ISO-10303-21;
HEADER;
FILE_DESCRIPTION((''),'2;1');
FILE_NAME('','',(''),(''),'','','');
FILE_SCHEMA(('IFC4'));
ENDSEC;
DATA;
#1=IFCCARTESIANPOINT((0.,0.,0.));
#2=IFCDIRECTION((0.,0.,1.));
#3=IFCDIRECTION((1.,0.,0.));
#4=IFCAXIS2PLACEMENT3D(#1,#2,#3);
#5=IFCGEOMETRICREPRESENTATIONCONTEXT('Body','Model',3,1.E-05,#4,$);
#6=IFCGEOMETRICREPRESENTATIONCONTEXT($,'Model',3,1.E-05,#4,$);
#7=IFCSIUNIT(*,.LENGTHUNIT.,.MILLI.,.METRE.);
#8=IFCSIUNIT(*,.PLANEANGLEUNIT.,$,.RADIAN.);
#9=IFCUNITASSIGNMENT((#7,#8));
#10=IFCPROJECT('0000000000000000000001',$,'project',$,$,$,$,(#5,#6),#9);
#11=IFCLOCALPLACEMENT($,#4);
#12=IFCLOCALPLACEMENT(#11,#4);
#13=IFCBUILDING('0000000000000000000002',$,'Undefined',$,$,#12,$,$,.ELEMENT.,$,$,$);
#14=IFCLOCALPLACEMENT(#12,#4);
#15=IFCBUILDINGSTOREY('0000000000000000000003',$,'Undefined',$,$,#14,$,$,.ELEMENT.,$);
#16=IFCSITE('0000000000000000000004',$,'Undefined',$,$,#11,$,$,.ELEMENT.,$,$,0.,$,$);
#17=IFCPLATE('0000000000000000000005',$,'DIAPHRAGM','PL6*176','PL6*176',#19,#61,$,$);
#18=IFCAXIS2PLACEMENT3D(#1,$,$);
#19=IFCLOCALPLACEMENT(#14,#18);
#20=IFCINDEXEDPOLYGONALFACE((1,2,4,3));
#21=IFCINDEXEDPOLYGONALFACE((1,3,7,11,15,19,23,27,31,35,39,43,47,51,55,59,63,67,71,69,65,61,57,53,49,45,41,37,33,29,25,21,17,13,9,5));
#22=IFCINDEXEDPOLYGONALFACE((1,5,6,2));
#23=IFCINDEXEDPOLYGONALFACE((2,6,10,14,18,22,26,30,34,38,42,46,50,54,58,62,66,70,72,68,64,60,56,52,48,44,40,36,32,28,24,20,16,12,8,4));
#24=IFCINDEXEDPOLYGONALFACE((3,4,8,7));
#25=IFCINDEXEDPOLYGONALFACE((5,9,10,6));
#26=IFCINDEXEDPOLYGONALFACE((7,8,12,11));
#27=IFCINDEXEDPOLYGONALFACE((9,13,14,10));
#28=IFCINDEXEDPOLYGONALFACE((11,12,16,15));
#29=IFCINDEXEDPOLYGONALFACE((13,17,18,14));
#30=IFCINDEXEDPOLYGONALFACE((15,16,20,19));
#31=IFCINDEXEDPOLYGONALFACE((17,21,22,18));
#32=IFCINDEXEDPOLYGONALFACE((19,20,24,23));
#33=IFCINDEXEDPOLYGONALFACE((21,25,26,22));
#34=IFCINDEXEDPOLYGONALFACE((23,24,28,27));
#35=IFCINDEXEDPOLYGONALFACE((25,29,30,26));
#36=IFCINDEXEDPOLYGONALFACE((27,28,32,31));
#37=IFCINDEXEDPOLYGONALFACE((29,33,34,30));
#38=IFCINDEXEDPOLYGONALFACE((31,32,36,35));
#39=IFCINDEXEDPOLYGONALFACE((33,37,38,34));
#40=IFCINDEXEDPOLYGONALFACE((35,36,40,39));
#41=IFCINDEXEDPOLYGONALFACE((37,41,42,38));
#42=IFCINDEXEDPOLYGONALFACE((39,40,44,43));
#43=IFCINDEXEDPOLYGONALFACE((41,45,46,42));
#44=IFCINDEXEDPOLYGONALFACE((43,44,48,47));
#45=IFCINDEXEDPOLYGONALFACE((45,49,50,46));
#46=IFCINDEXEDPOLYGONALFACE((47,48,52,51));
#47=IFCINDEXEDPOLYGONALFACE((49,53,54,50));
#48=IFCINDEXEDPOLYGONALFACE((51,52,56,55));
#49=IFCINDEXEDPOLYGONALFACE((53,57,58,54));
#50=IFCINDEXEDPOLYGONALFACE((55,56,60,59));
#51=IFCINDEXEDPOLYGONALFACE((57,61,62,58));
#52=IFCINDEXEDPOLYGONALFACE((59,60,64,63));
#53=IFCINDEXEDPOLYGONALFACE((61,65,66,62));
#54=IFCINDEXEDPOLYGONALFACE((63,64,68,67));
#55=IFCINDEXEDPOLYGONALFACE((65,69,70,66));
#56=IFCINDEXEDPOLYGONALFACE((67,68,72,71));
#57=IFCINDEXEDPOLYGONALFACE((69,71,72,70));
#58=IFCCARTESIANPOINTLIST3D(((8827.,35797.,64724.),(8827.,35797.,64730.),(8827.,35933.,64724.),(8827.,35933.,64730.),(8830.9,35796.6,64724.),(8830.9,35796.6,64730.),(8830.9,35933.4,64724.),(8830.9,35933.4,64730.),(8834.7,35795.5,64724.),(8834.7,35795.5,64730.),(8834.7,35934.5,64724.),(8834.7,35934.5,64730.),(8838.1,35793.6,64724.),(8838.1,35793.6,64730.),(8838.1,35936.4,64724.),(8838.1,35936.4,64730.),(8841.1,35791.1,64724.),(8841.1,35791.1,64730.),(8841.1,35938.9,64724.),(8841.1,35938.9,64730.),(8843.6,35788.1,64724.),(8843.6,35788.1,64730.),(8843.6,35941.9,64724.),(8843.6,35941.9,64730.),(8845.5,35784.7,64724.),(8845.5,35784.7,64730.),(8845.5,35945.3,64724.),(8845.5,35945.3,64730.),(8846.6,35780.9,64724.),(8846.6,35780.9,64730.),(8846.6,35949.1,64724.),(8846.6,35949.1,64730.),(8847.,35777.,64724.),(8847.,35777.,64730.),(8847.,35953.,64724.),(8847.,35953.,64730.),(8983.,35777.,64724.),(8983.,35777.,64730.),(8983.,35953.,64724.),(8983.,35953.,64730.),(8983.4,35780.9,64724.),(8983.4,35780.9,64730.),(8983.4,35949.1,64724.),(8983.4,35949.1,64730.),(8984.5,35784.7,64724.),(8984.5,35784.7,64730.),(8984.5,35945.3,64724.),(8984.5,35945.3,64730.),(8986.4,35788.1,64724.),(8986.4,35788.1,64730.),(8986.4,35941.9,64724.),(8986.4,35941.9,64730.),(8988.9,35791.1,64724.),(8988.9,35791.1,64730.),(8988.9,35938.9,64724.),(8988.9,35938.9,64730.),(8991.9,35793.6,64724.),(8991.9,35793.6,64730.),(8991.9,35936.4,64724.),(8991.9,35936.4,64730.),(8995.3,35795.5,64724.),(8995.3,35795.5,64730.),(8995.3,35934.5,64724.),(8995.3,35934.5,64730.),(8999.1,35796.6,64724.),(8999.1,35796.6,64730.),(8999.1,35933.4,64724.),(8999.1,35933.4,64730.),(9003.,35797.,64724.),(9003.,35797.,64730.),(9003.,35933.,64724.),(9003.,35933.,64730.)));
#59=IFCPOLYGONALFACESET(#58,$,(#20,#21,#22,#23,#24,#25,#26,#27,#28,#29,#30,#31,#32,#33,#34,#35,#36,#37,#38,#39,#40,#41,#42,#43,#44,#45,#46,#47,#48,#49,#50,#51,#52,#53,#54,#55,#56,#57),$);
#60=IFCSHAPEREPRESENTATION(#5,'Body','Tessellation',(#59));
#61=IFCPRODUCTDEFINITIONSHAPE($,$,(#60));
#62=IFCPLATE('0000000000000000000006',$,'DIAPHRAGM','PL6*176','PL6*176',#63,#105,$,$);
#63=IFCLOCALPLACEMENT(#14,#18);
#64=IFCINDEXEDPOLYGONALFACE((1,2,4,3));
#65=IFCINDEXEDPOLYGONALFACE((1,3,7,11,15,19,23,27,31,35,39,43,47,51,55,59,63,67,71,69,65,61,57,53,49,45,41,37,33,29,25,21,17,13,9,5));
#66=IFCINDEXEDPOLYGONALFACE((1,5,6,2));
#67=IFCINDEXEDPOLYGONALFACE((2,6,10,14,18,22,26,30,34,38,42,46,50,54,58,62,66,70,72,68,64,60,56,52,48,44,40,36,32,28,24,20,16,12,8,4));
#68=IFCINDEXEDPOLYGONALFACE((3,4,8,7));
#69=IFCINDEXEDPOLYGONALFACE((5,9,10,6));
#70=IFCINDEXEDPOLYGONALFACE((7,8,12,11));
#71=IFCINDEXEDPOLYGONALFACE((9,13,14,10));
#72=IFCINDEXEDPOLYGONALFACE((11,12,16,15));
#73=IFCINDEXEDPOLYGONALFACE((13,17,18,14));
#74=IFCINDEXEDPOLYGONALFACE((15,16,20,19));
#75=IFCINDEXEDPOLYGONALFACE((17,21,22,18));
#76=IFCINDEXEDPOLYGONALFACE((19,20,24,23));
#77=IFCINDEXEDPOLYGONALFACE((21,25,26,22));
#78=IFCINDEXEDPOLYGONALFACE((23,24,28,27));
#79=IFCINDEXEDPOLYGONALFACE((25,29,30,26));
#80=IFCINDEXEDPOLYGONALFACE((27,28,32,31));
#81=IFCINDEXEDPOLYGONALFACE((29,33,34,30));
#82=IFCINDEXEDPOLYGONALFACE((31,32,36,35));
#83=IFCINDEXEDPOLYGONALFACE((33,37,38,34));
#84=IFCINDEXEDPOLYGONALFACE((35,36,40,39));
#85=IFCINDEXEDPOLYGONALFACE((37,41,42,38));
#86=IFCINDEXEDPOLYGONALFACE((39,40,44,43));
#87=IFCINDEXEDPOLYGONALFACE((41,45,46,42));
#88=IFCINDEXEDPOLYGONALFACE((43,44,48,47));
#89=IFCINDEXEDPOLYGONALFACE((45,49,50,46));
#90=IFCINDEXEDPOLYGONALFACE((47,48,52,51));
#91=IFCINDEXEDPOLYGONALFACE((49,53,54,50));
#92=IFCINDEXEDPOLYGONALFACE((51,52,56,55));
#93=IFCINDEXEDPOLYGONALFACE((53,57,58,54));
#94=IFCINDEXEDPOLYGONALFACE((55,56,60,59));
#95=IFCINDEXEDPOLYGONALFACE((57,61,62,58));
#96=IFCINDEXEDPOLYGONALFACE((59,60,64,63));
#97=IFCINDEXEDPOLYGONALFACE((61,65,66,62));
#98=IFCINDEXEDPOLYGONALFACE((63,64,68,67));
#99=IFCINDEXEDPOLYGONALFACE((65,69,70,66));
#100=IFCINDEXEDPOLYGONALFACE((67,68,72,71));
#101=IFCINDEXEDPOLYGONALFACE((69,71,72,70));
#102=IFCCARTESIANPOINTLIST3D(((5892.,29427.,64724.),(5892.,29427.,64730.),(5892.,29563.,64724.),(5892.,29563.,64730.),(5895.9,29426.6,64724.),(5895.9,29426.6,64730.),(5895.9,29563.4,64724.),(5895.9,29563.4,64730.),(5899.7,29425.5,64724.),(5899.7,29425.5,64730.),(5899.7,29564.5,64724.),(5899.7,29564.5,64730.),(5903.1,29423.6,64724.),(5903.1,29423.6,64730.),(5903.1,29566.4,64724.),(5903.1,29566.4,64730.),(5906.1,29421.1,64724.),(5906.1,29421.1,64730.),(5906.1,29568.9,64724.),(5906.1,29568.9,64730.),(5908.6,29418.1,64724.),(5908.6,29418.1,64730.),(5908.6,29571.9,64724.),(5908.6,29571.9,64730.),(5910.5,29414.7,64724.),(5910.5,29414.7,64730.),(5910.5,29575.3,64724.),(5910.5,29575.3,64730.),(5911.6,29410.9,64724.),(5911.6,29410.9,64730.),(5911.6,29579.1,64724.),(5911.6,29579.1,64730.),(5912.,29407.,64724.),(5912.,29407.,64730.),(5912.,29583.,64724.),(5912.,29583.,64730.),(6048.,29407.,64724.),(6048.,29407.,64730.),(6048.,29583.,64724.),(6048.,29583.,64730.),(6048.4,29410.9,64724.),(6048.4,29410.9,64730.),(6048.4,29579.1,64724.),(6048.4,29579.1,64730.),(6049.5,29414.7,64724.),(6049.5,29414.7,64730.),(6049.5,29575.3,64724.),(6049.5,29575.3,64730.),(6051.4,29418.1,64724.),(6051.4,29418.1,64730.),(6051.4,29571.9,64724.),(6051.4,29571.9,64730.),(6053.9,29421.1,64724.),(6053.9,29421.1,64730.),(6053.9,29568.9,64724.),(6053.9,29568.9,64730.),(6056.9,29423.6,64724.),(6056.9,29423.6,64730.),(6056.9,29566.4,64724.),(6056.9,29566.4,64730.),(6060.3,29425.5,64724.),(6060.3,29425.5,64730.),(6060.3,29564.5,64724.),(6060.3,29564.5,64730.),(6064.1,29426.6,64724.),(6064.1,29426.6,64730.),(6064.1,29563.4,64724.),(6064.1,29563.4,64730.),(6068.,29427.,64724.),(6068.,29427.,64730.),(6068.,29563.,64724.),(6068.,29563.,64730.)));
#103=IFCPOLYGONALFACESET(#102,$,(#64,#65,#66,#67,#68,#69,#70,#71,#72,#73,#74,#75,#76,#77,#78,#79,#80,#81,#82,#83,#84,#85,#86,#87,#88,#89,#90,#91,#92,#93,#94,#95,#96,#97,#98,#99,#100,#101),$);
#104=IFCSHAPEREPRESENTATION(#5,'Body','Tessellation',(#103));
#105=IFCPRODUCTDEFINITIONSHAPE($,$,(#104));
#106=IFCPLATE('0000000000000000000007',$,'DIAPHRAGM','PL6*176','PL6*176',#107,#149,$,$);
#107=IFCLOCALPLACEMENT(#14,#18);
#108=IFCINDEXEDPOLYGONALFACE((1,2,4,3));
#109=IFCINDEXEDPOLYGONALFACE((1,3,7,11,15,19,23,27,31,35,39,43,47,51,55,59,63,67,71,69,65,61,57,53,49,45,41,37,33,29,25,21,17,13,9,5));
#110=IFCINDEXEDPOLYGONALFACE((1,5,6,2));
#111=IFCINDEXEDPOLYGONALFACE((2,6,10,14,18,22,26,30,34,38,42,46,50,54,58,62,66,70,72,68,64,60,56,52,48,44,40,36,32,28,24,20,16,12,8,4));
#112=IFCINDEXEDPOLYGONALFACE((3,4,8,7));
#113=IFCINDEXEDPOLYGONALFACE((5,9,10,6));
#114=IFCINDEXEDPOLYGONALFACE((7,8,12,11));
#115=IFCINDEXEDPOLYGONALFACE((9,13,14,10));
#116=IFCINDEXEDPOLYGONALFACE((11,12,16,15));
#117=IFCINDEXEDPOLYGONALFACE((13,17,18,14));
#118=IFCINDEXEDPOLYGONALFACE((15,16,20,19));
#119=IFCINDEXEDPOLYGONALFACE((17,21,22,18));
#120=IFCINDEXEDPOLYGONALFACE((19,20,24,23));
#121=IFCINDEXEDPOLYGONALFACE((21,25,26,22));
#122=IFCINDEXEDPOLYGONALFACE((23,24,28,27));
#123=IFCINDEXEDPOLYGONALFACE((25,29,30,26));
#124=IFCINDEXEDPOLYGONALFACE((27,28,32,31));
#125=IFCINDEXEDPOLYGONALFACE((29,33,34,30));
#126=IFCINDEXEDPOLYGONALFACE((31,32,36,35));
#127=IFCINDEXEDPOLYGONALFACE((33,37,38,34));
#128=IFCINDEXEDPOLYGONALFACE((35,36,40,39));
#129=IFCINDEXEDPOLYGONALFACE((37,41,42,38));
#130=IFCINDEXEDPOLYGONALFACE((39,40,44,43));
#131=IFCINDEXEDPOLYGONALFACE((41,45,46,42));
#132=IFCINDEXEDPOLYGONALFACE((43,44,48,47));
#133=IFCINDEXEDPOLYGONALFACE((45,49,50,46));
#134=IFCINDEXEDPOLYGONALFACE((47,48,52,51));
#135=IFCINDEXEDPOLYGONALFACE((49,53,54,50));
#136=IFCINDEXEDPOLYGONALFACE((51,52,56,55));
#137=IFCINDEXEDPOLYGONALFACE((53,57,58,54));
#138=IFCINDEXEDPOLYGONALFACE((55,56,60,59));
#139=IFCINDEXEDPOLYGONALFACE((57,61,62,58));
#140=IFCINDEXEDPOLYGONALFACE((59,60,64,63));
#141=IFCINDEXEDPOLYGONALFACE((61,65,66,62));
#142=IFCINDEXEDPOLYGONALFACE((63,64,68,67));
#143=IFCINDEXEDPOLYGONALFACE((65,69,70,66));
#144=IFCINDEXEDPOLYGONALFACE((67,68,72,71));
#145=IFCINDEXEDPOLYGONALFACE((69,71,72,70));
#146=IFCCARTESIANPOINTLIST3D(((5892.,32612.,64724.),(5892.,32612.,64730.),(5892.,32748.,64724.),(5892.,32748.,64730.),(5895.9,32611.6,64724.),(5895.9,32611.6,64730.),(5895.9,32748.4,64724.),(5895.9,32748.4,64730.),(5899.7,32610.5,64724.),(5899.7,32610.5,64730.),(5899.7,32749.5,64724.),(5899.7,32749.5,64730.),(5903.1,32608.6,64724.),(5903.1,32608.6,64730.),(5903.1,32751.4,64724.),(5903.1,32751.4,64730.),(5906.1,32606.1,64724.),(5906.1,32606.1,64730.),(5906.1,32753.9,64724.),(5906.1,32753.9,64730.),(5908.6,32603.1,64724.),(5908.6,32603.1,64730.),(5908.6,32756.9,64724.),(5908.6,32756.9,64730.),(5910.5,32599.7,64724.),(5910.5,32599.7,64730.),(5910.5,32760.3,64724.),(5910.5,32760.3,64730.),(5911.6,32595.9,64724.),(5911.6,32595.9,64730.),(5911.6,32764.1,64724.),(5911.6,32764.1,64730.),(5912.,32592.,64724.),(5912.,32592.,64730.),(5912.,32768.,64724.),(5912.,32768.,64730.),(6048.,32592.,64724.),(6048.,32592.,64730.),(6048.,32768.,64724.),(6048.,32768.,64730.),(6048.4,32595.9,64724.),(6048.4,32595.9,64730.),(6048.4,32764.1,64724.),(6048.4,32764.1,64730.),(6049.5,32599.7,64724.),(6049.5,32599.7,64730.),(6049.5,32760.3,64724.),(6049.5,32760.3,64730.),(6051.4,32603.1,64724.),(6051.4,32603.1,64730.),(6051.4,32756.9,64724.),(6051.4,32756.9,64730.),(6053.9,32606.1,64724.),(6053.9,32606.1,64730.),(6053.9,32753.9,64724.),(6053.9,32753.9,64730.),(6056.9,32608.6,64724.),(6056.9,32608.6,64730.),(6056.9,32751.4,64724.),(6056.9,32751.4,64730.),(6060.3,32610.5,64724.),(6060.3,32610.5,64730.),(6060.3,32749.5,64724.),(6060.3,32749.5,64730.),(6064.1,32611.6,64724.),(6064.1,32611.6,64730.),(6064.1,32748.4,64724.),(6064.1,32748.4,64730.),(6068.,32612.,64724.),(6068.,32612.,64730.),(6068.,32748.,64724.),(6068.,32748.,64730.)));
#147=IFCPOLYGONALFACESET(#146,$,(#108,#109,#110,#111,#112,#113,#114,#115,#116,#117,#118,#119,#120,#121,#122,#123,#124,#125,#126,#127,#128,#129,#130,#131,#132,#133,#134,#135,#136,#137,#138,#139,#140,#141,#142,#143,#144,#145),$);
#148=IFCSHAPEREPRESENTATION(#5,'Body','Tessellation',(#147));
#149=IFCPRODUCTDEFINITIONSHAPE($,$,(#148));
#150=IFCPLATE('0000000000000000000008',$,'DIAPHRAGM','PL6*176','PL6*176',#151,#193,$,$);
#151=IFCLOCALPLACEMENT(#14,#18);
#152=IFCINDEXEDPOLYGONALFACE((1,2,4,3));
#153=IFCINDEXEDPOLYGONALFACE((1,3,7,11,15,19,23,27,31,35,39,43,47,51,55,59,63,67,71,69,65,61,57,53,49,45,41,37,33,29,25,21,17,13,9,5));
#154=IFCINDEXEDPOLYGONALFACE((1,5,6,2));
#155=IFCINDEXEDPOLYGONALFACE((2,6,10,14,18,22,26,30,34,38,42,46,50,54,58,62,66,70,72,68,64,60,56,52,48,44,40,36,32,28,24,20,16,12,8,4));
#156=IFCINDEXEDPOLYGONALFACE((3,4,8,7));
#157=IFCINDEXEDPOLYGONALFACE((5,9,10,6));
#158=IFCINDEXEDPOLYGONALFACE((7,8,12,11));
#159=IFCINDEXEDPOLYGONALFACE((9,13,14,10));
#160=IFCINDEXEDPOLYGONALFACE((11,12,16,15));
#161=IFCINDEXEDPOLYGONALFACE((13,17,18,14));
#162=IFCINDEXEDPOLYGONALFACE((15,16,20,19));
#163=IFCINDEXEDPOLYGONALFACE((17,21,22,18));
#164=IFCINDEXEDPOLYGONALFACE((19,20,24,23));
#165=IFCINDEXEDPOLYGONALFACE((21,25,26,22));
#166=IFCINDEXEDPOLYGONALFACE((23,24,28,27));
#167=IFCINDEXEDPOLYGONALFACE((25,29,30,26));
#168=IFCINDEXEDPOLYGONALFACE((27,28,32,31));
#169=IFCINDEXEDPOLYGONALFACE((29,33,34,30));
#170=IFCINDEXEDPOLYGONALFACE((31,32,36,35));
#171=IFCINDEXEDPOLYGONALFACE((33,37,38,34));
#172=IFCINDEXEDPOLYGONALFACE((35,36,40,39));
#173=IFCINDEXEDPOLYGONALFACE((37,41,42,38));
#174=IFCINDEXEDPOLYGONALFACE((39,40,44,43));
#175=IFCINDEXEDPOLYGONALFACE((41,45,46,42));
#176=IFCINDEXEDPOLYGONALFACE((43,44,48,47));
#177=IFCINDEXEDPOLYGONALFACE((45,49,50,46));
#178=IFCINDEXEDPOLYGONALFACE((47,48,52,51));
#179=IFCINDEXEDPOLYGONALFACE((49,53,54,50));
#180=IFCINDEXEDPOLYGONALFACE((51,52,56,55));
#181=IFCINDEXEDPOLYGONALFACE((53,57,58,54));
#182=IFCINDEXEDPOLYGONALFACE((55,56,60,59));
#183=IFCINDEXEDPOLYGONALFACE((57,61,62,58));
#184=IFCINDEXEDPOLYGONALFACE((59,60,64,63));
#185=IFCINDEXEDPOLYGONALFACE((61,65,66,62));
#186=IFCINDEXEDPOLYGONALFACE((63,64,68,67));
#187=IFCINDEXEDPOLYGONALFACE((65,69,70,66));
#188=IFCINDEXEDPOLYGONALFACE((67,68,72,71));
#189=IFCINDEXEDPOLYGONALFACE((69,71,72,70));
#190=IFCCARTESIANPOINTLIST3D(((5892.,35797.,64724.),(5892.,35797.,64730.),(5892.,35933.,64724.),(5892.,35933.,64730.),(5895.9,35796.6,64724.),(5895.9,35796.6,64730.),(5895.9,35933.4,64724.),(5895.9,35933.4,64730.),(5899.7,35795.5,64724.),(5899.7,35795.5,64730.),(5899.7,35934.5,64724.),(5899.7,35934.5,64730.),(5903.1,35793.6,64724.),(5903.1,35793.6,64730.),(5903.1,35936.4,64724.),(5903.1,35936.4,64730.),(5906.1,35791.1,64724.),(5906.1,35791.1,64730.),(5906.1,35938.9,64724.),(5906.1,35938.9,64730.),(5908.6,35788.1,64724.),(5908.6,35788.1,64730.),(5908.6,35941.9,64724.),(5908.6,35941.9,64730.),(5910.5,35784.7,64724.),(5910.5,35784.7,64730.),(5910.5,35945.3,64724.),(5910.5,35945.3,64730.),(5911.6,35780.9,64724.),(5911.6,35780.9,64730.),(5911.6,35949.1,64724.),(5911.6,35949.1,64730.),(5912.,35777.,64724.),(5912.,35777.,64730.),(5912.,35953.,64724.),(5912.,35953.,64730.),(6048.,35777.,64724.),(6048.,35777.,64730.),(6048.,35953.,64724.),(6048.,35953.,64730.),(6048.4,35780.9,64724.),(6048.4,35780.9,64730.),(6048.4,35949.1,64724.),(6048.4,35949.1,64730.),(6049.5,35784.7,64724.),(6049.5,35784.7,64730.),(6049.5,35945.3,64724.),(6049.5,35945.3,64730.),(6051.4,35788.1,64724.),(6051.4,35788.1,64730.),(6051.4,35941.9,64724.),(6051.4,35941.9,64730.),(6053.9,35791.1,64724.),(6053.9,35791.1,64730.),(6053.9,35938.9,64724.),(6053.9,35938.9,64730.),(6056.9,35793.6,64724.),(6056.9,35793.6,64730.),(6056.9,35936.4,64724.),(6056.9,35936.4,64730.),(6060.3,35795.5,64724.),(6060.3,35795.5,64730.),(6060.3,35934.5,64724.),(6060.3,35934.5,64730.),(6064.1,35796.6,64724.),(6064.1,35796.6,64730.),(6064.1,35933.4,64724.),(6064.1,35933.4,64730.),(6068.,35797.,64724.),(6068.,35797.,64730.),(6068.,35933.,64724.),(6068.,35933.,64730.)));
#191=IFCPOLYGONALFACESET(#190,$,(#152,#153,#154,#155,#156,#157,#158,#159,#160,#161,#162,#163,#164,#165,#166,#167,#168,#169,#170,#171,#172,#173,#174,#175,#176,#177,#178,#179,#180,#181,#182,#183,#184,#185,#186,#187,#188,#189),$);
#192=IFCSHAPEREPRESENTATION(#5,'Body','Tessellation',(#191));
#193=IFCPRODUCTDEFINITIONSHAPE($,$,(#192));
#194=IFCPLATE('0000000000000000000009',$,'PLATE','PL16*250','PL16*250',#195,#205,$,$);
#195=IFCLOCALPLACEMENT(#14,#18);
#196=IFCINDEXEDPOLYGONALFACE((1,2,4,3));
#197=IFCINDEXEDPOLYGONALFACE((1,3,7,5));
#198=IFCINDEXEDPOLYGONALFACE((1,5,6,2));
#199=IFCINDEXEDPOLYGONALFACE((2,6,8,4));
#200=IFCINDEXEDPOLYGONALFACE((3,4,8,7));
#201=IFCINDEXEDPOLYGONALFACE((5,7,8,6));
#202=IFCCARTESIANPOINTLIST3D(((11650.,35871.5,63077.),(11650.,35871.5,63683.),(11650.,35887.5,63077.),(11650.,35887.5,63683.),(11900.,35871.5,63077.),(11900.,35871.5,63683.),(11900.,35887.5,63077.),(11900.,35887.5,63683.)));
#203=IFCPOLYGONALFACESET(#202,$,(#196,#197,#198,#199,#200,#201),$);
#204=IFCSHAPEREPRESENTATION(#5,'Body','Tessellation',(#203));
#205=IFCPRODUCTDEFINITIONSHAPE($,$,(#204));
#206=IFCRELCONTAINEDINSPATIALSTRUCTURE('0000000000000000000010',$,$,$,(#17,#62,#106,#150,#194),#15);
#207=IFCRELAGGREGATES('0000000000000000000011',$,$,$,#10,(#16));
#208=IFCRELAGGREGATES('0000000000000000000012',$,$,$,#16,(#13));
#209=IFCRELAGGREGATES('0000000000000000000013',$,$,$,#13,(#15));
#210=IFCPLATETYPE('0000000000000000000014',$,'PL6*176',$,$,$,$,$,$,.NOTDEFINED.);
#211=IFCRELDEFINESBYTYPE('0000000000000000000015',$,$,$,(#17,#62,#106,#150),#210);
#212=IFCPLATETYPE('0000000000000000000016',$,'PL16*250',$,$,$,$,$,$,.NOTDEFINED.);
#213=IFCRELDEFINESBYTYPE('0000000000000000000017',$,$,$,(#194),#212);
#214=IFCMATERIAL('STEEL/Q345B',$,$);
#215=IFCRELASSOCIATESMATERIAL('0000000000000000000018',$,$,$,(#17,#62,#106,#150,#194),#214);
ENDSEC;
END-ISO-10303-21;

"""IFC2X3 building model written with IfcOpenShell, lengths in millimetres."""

from ifc_helpers import new_model, si_unit, frame, origin_with_axes, place, context, project, spatial, polyline, outline, extrude, material, type_object, element, save


model = new_model("IFC2X3")

# Units and contexts
model_context_1 = context("Model", 3, precision=1e-05, world=origin_with_axes(), identifier="Body")
model_context_2 = context("Model", 3, precision=1e-05, world=origin_with_axes())
ifc_project = project(units=[si_unit("LENGTHUNIT", "METRE", prefix="MILLI"), si_unit("PLANEANGLEUNIT", "RADIAN")], contexts=[model_context_1, model_context_2])

# Site, building, storey
site_placement = place(None, origin_with_axes())
site = spatial("IfcSite", under=ifc_project, at=site_placement, Name="Undefined", CompositionType="ELEMENT", RefElevation=0.0)
building_placement = place(site_placement, origin_with_axes())
building = spatial("IfcBuilding", under=site, at=building_placement, Name="Undefined", CompositionType="ELEMENT")
storey_placement = place(building_placement, origin_with_axes())
storey = spatial("IfcBuildingStorey", under=building, at=storey_placement, Name="Undefined", CompositionType="ELEMENT")

# Shared definitions
ifc_material_1 = material(Name="STEEL/Q345B")

# Plates
plate_type_1 = type_object("IfcPlateType", Name="PL6*176", PredefinedType="NOTDEFINED")
for number, where, z_axis, x_axis, name in (
    (1, (9003.0, 35777.0, 64727.0), (0.0, 0.0, -1.0), (-1.0, 0.0, 0.0), "DIAPHRAGM"),
    (2, (6068.0, 29407.0, 64727.0), (0.0, 0.0, -1.0), (-1.0, 0.0, 0.0), "DIAPHRAGM"),
    (3, (6068.0, 32592.0, 64727.0), (0.0, 0.0, -1.0), (-1.0, 0.0, 0.0), "DIAPHRAGM"),
    (4, (6068.0, 35777.0, 64727.0), (0.0, 0.0, -1.0), (-1.0, 0.0, 0.0), "DIAPHRAGM"),
):
    element("IfcPlate", number, at=place(storey_placement, frame(where, z_axis=z_axis, x_axis=x_axis)), inside=storey, type_object=plate_type_1, material=ifc_material_1, Name=name, Description="PL6*176", ObjectType="PL6*176", context=model_context_1, shape_type="SweptSolid", body=[
        extrude(outline(polyline([(0.0, 20.0), (3.9, 19.6), (7.7, 18.5), (11.1, 16.6), (14.1, 14.1), (16.6, 11.1), (18.5, 7.7), (19.6, 3.9), (20.0, 0.0), (156.0, 0.0), (156.4, 3.9), (157.5, 7.7), (159.4, 11.1), (161.9, 14.1), (164.9, 16.6), (168.3, 18.5), (172.1, 19.6), (176.0, 20.0), (176.0, 156.0), (172.1, 156.4), (168.3, 157.5), (164.9, 159.4), (161.9, 161.9), (159.4, 164.9), (157.5, 168.3), (156.4, 172.1), (156.0, 176.0), (20.0, 176.0), (19.6, 172.1), (18.5, 168.3), (16.6, 164.9), (14.1, 161.9), (11.1, 159.4), (7.7, 157.5), (3.9, 156.4), (0.0, 156.0), (0.0, 20.0)])), frame((0.0, 0.0, -3.0), z_axis=(0.0, 0.0, 1.0), x_axis=(1.0, 0.0, 0.0)), (0.0, 0.0, 1.0), 6.0),
    ])
plate_type_2 = type_object("IfcPlateType", Name="PL16*250", PredefinedType="NOTDEFINED")
plate_1_placement = place(storey_placement, frame((11650.0, 35879.5, 63683.0), z_axis=(0.0, 1.0, 0.0), x_axis=(1.0, 0.0, 0.0)))
element("IfcPlate", 5, at=plate_1_placement, inside=storey, type_object=plate_type_2, material=ifc_material_1, Name="PLATE", Description="PL16*250", ObjectType="PL16*250", context=model_context_1, shape_type="SweptSolid", body=[
    extrude(outline(polyline([(0.0, 0.0), (250.0, 0.0), (250.0, 606.0), (0.0, 606.0), (0.0, 0.0)])), frame((0.0, 0.0, -8.0), z_axis=(0.0, 0.0, 1.0), x_axis=(1.0, 0.0, 0.0)), (0.0, 0.0, 1.0), 16.0),
])

save(model, "model.ifc")
